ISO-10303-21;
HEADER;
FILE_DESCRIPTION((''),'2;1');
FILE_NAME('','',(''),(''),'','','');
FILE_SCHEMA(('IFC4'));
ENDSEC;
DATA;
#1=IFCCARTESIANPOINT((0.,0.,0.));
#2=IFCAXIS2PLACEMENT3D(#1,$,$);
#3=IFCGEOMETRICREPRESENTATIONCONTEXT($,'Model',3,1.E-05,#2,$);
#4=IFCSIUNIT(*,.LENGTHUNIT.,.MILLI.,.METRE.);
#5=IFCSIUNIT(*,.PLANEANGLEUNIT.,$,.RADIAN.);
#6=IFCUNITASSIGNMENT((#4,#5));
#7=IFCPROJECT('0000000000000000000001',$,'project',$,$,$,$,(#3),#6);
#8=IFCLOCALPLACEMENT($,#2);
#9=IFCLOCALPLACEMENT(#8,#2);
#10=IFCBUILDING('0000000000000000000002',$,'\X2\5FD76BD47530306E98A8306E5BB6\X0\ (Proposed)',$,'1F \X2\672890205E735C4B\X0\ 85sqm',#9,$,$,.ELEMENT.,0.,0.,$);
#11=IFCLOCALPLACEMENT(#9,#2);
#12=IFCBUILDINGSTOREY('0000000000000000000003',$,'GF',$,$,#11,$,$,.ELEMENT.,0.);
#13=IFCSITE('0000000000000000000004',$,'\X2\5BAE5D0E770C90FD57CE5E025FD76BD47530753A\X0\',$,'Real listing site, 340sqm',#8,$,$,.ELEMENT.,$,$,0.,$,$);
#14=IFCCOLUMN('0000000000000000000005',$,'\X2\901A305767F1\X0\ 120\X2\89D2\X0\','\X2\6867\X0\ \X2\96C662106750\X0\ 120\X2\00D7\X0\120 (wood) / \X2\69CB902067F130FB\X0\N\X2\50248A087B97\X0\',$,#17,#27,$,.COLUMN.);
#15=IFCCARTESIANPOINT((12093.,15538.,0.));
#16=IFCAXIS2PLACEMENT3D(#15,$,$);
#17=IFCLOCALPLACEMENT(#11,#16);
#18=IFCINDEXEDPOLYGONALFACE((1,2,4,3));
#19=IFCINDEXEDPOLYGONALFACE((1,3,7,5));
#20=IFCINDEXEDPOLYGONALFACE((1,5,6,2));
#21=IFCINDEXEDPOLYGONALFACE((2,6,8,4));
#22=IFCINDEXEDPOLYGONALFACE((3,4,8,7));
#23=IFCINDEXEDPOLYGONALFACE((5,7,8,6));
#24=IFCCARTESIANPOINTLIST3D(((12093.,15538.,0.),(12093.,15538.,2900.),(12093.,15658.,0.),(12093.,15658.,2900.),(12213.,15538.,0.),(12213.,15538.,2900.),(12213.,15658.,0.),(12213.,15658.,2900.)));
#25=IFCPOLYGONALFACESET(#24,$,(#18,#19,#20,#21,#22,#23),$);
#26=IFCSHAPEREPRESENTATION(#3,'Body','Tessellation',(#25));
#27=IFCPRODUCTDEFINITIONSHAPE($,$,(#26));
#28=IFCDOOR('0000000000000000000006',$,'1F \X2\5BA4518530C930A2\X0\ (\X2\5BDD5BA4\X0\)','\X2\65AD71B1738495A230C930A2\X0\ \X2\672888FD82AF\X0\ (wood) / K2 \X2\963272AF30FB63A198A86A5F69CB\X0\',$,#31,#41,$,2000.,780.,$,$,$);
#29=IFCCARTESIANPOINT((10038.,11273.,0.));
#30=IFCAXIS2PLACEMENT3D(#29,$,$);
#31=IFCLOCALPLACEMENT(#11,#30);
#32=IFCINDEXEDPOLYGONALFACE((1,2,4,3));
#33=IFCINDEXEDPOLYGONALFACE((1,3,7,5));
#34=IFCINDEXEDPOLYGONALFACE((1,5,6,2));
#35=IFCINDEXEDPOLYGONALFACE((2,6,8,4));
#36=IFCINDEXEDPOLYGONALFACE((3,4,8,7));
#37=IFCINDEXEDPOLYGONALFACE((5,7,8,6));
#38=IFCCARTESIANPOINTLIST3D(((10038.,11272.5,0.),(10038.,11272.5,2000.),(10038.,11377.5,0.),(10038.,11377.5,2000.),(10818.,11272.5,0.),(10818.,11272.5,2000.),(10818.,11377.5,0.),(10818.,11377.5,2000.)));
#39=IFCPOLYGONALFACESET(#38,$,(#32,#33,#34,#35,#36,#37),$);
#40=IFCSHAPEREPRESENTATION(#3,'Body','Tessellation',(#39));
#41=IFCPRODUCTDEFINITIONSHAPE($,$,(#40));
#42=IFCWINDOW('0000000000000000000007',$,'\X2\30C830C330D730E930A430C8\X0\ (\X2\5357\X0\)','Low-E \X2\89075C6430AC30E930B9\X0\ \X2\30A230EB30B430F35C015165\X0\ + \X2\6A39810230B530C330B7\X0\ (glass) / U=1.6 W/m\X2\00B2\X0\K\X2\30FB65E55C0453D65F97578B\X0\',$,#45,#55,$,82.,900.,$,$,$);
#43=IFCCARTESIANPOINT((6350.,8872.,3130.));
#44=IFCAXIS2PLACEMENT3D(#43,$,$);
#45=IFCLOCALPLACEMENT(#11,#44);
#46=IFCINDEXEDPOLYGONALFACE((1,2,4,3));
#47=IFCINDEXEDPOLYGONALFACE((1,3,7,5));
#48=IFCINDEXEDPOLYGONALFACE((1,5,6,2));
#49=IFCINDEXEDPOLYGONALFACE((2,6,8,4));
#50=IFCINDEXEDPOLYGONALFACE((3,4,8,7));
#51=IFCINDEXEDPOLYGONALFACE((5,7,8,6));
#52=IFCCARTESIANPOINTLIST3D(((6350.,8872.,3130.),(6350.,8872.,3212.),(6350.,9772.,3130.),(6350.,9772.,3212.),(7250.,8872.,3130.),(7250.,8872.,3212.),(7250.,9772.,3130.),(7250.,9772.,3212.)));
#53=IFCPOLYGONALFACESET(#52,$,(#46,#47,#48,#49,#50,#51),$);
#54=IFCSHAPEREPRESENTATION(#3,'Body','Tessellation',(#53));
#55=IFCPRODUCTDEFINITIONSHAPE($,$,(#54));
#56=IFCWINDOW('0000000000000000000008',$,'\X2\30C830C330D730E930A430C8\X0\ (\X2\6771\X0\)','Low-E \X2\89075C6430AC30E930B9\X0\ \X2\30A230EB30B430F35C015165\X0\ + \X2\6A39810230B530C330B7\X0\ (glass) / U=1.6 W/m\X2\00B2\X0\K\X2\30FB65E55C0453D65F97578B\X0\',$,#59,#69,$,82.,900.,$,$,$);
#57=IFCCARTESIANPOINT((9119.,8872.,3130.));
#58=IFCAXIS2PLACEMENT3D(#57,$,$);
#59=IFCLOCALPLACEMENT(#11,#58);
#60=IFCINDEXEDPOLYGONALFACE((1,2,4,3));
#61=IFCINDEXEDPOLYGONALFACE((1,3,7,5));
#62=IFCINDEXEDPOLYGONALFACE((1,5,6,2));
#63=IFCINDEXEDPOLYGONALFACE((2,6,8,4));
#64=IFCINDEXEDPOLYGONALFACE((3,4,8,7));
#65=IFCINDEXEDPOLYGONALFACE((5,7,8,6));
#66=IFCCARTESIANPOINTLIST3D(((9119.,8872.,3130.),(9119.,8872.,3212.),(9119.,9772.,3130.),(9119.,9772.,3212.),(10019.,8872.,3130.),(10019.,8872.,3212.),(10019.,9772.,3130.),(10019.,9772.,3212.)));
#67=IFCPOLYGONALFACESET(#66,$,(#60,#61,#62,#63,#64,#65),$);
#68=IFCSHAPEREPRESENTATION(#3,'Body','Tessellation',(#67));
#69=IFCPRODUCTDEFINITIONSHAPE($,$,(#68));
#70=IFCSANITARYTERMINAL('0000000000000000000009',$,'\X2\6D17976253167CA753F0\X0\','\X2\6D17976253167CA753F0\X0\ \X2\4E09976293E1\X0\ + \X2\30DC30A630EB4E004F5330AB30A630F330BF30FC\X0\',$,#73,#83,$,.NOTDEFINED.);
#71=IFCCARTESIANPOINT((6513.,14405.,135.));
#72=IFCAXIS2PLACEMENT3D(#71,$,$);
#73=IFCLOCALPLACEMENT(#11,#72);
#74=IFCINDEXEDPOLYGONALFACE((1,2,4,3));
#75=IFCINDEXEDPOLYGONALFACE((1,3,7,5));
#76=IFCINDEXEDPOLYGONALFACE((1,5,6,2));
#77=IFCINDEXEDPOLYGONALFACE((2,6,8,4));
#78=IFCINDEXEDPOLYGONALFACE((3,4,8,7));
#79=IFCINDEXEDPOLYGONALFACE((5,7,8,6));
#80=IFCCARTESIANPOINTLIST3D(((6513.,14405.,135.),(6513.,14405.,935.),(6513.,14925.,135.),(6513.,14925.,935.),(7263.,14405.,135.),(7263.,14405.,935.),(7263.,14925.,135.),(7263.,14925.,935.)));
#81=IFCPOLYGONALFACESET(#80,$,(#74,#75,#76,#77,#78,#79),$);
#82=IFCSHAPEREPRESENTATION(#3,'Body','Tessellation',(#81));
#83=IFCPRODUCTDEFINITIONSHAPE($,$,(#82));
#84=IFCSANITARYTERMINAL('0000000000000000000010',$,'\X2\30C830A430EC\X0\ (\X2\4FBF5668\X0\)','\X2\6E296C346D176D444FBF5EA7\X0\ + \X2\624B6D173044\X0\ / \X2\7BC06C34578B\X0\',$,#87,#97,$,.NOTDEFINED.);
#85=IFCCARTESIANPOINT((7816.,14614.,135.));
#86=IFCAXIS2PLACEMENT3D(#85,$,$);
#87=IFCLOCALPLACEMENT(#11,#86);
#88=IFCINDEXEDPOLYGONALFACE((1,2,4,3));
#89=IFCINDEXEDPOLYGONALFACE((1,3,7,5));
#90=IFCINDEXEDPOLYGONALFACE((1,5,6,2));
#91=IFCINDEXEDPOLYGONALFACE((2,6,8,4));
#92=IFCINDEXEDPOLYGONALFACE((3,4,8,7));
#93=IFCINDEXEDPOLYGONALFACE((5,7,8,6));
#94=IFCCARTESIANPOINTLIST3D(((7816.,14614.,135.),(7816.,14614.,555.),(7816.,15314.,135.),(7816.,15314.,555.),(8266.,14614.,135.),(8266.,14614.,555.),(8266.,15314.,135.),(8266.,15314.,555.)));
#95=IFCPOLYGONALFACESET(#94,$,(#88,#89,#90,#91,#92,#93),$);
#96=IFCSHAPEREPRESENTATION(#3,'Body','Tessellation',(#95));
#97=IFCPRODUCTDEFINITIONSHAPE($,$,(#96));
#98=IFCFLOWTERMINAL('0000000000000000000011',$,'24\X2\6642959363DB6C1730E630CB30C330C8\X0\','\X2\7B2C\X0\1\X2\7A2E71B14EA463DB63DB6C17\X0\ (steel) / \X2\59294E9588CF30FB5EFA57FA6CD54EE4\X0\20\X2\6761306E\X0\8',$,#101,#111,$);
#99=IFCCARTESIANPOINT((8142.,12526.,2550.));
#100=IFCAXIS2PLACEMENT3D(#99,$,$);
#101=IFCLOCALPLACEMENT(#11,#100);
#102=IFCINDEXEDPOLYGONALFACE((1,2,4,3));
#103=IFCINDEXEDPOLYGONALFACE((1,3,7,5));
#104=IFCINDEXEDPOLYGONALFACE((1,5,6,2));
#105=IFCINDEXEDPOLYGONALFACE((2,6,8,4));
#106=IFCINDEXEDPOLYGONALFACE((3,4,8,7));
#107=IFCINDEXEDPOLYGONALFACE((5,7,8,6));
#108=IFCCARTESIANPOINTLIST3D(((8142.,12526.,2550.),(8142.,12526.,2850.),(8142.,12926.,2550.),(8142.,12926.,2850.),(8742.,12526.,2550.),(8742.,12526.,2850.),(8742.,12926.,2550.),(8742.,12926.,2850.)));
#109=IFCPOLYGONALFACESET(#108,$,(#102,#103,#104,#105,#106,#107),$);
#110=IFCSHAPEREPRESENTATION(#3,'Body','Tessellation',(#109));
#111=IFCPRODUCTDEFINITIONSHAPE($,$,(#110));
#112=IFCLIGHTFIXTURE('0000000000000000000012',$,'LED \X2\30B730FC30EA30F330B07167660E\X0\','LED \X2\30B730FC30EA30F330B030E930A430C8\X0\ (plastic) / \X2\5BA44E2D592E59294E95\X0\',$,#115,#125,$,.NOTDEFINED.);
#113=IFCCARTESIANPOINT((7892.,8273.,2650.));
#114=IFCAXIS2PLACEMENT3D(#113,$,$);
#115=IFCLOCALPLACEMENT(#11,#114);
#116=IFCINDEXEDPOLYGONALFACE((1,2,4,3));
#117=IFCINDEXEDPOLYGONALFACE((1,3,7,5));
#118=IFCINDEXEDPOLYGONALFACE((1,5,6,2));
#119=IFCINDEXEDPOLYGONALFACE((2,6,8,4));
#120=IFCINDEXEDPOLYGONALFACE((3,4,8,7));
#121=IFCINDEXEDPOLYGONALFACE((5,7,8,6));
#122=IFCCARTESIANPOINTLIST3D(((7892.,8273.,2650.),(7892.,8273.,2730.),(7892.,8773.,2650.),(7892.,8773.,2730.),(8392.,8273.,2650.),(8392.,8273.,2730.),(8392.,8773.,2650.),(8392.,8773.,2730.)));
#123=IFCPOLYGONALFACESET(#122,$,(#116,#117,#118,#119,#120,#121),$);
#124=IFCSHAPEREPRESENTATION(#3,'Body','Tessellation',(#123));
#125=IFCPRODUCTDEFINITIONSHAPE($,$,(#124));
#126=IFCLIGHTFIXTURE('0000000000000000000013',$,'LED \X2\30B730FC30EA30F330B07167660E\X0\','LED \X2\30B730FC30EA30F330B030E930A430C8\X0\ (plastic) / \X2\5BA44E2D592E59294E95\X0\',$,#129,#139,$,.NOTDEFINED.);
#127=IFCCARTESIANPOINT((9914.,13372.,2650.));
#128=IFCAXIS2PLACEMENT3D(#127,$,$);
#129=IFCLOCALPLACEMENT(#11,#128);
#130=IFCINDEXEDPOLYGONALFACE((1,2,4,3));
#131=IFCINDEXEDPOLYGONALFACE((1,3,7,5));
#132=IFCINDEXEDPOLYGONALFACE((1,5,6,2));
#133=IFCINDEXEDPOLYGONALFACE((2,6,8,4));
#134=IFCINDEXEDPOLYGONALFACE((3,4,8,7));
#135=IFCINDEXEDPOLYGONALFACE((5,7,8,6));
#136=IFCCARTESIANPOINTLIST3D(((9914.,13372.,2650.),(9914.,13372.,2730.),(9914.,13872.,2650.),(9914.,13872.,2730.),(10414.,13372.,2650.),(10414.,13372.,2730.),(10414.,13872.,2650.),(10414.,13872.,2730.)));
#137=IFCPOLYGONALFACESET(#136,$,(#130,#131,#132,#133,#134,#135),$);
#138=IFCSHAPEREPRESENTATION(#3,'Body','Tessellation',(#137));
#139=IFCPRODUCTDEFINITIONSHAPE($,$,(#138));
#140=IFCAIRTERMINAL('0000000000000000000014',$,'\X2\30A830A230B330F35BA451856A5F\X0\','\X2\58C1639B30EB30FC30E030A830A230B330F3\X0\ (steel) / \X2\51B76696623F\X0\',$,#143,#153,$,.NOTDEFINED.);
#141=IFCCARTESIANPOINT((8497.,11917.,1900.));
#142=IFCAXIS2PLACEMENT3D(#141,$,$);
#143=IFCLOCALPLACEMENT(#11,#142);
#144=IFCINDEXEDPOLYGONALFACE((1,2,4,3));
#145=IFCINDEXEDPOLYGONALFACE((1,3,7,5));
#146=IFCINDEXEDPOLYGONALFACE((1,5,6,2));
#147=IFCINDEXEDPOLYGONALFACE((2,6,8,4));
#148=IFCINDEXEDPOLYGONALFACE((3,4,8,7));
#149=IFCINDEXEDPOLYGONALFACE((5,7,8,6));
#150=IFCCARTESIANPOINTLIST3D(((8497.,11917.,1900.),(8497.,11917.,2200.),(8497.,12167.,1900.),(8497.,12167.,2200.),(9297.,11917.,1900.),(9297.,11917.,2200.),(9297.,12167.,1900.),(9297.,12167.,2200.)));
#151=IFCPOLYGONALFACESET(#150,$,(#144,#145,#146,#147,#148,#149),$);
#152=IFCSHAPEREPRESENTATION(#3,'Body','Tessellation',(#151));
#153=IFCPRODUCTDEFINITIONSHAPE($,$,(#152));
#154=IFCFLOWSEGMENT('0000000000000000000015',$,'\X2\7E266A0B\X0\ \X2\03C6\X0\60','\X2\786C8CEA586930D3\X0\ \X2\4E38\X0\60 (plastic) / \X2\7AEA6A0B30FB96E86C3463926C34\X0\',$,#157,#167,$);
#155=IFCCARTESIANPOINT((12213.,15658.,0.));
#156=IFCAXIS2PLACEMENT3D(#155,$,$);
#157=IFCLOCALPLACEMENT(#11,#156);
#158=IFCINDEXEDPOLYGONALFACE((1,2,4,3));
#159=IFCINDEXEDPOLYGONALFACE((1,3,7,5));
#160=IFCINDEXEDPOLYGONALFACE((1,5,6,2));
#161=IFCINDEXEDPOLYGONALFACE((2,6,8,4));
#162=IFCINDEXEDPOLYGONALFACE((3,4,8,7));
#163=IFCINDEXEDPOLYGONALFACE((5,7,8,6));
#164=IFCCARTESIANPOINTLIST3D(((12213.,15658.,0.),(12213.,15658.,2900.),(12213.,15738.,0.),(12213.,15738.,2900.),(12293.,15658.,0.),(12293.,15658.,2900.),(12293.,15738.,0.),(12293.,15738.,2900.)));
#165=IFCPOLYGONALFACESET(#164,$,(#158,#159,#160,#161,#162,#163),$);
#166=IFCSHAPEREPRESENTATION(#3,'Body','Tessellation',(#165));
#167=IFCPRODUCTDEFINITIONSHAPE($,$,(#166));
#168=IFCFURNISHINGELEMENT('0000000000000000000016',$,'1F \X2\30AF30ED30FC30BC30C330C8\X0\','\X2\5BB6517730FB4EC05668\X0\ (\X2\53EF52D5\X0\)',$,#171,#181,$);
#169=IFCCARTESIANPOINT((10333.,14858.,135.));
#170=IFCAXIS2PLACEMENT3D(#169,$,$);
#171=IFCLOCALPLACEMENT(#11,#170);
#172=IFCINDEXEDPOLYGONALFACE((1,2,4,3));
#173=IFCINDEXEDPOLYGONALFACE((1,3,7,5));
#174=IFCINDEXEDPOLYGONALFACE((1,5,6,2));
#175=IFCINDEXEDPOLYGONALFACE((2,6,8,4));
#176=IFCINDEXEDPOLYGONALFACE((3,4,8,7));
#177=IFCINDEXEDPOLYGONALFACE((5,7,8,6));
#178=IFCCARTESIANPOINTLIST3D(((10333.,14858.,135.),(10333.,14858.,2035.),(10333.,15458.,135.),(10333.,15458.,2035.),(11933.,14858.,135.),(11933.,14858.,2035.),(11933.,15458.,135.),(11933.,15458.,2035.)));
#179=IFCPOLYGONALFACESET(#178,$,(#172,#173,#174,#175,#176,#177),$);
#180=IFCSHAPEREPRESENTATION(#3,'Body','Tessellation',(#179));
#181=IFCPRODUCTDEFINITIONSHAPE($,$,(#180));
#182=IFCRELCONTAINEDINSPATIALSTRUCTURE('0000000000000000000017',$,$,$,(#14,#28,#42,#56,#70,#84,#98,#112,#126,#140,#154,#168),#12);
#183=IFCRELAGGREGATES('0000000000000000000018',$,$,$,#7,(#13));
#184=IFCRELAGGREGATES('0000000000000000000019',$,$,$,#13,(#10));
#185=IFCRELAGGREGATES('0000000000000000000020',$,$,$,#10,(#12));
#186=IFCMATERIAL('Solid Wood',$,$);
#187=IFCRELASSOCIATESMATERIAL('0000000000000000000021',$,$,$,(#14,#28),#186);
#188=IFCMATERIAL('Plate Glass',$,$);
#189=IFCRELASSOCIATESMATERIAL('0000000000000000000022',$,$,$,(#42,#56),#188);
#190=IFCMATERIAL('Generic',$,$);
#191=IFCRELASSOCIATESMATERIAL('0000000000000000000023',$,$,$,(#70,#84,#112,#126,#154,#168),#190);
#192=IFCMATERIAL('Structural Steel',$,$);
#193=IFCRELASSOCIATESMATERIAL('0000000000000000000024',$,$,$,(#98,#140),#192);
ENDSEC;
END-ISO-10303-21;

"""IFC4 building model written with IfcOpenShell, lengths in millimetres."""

from ifc_helpers import new_model, si_unit, frame, frame_2d, origin, place, context, project, spatial, rectangle, extrude, material, element, save


model = new_model("IFC4")

# Units and contexts
model_context = context("Model", 3, precision=1e-05, world=origin())
ifc_project = project(units=[si_unit("LENGTHUNIT", "METRE", prefix="MILLI"), si_unit("PLANEANGLEUNIT", "RADIAN")], contexts=[model_context])

# Site, building, storey
site_placement = place(None, origin())
site = spatial("IfcSite", under=ifc_project, at=site_placement, Name="宮崎県都城市志比田町", ObjectType="Real listing site, 340sqm", CompositionType="ELEMENT", RefElevation=0.0)
building_placement = place(site_placement, origin())
building = spatial("IfcBuilding", under=site, at=building_placement, Name="志比田の風の家 (Proposed)", ObjectType="1F 木造平屋 85sqm", CompositionType="ELEMENT", ElevationOfRefHeight=0.0, ElevationOfTerrain=0.0)
storey_placement = place(building_placement, origin())
storey = spatial("IfcBuildingStorey", under=building, at=storey_placement, Name="GF", CompositionType="ELEMENT", Elevation=0.0)

# Column
ifc_material_1 = material(Name="Solid Wood")
column_1_placement = place(storey_placement, frame((12093.0, 15538.0, 0.0)))
element("IfcColumn", 1, at=column_1_placement, inside=storey, material=ifc_material_1, Name="通し柱 120角", Description="桧 集成材 120×120 (wood) / 構造柱・N値計算", PredefinedType="COLUMN", context=model_context, shape_type="SweptSolid", body=[
    extrude(rectangle(XDim=120.0, YDim=120.0, at=frame_2d((60.0, 60.0))), frame((12093.0, 15538.0, 0.0)), (0.0, 0.0, 1.0), 2900.0),
])

# Door
door_placement = place(storey_placement, frame((10038.0, 11273.0, 0.0)))
element("IfcDoor", 2, at=door_placement, inside=storey, material=ifc_material_1, Name="1F 室内ドア (寝室)", Description="断熱玄関ドア 木製芯 (wood) / K2 防犯・採風機構", OverallHeight=2000.0, OverallWidth=780.0, context=model_context, shape_type="SweptSolid", body=[
    extrude(rectangle(XDim=780.0, YDim=105.0, at=frame_2d((390.0, 52.0))), frame((10038.0, 11273.0, 0.0)), (0.0, 0.0, 1.0), 2000.0),
])

# Windows
ifc_material_2 = material(Name="Plate Glass")
window_1_placement = place(storey_placement, frame((6350.0, 8872.0, 3130.0)))
element("IfcWindow", 3, at=window_1_placement, inside=storey, material=ifc_material_2, Name="トップライト (南)", Description="Low-E 複層ガラス アルゴン封入 + 樹脂サッシ (glass) / U=1.6 W/m²K・日射取得型", OverallHeight=82.0, OverallWidth=900.0, context=model_context, shape_type="SweptSolid", body=[
    extrude(rectangle(XDim=900.0, YDim=900.0, at=frame_2d((450.0, 450.0))), frame((6350.0, 8872.0, 3130.0)), (0.0, 0.0, 1.0), 82.0),
])
window_2_placement = place(storey_placement, frame((9119.0, 8872.0, 3130.0)))
element("IfcWindow", 4, at=window_2_placement, inside=storey, material=ifc_material_2, Name="トップライト (東)", Description="Low-E 複層ガラス アルゴン封入 + 樹脂サッシ (glass) / U=1.6 W/m²K・日射取得型", OverallHeight=82.0, OverallWidth=900.0, context=model_context, shape_type="SweptSolid", body=[
    extrude(rectangle(XDim=900.0, YDim=900.0, at=frame_2d((450.0, 450.0))), frame((9119.0, 8872.0, 3130.0)), (0.0, 0.0, 1.0), 82.0),
])

# Sanitary terminals
ifc_material_3 = material(Name="Generic")
sanitary_terminal_1_placement = place(storey_placement, frame((6513.0, 14405.0, 135.0)))
element("IfcSanitaryTerminal", 5, at=sanitary_terminal_1_placement, inside=storey, material=ifc_material_3, Name="洗面化粧台", Description="洗面化粧台 三面鏡 + ボウル一体カウンター", PredefinedType="NOTDEFINED", context=model_context, shape_type="SweptSolid", body=[
    extrude(rectangle(XDim=750.0, YDim=520.0, at=frame_2d((375.0, 260.0))), frame((6513.0, 14405.0, 135.0)), (0.0, 0.0, 1.0), 800.0),
])
sanitary_terminal_2_placement = place(storey_placement, frame((7816.0, 14614.0, 135.0)))
element("IfcSanitaryTerminal", 6, at=sanitary_terminal_2_placement, inside=storey, material=ifc_material_3, Name="トイレ (便器)", Description="温水洗浄便座 + 手洗い / 節水型", PredefinedType="NOTDEFINED", context=model_context, shape_type="SweptSolid", body=[
    extrude(rectangle(XDim=450.0, YDim=700.0, at=frame_2d((225.0, 350.0))), frame((7816.0, 14614.0, 135.0)), (0.0, 0.0, 1.0), 420.0),
])

# Flow terminal
ifc_material_4 = material(Name="Structural Steel")
flow_terminal_placement = place(storey_placement, frame((8142.0, 12526.0, 2550.0)))
element("IfcFlowTerminal", 7, at=flow_terminal_placement, inside=storey, material=ifc_material_4, Name="24時間換気ユニット", Description="第1種熱交換換気 (steel) / 天井裏・建基法令20条の8", context=model_context, shape_type="SweptSolid", body=[
    extrude(rectangle(XDim=600.0, YDim=400.0, at=frame_2d((300.0, 200.0))), frame((8142.0, 12526.0, 2550.0)), (0.0, 0.0, 1.0), 300.0),
])

# Light fixtures
light_fixture_1_placement = place(storey_placement, frame((7892.0, 8273.0, 2650.0)))
element("IfcLightFixture", 8, at=light_fixture_1_placement, inside=storey, material=ifc_material_3, Name="LED シーリング照明", Description="LED シーリングライト (plastic) / 室中央天井", PredefinedType="NOTDEFINED", context=model_context, shape_type="SweptSolid", body=[
    extrude(rectangle(XDim=500.0, YDim=500.0, at=frame_2d((250.0, 250.0))), frame((7892.0, 8273.0, 2650.0)), (0.0, 0.0, 1.0), 80.0),
])
light_fixture_2_placement = place(storey_placement, frame((9914.0, 13372.0, 2650.0)))
element("IfcLightFixture", 9, at=light_fixture_2_placement, inside=storey, material=ifc_material_3, Name="LED シーリング照明", Description="LED シーリングライト (plastic) / 室中央天井", PredefinedType="NOTDEFINED", context=model_context, shape_type="SweptSolid", body=[
    extrude(rectangle(XDim=500.0, YDim=500.0, at=frame_2d((250.0, 250.0))), frame((9914.0, 13372.0, 2650.0)), (0.0, 0.0, 1.0), 80.0),
])

# Air terminal
air_terminal_placement = place(storey_placement, frame((8497.0, 11917.0, 1900.0)))
element("IfcAirTerminal", 10, at=air_terminal_placement, inside=storey, material=ifc_material_4, Name="エアコン室内機", Description="壁掛ルームエアコン (steel) / 冷暖房", PredefinedType="NOTDEFINED", context=model_context, shape_type="SweptSolid", body=[
    extrude(rectangle(XDim=800.0, YDim=250.0, at=frame_2d((400.0, 125.0))), frame((8497.0, 11917.0, 1900.0)), (0.0, 0.0, 1.0), 300.0),
])

# Flow segment
flow_segment_placement = place(storey_placement, frame((12213.0, 15658.0, 0.0)))
element("IfcFlowSegment", 11, at=flow_segment_placement, inside=storey, material=ifc_material_3, Name="縦樋 φ60", Description="硬質塩ビ 丸60 (plastic) / 竪樋・雨水排水", context=model_context, shape_type="SweptSolid", body=[
    extrude(rectangle(XDim=80.0, YDim=80.0, at=frame_2d((40.0, 40.0))), frame((12213.0, 15658.0, 0.0)), (0.0, 0.0, 1.0), 2900.0),
])

# Furnishing element
furnishing_placement = place(storey_placement, frame((10333.0, 14858.0, 135.0)))
element("IfcFurnishingElement", 12, at=furnishing_placement, inside=storey, material=ifc_material_3, Name="1F クローゼット", Description="家具・什器 (可動)", context=model_context, shape_type="SweptSolid", body=[
    extrude(rectangle(XDim=1600.0, YDim=600.0, at=frame_2d((800.0, 300.0))), frame((10333.0, 14858.0, 135.0)), (0.0, 0.0, 1.0), 1900.0),
])

save(model, "model.ifc")
